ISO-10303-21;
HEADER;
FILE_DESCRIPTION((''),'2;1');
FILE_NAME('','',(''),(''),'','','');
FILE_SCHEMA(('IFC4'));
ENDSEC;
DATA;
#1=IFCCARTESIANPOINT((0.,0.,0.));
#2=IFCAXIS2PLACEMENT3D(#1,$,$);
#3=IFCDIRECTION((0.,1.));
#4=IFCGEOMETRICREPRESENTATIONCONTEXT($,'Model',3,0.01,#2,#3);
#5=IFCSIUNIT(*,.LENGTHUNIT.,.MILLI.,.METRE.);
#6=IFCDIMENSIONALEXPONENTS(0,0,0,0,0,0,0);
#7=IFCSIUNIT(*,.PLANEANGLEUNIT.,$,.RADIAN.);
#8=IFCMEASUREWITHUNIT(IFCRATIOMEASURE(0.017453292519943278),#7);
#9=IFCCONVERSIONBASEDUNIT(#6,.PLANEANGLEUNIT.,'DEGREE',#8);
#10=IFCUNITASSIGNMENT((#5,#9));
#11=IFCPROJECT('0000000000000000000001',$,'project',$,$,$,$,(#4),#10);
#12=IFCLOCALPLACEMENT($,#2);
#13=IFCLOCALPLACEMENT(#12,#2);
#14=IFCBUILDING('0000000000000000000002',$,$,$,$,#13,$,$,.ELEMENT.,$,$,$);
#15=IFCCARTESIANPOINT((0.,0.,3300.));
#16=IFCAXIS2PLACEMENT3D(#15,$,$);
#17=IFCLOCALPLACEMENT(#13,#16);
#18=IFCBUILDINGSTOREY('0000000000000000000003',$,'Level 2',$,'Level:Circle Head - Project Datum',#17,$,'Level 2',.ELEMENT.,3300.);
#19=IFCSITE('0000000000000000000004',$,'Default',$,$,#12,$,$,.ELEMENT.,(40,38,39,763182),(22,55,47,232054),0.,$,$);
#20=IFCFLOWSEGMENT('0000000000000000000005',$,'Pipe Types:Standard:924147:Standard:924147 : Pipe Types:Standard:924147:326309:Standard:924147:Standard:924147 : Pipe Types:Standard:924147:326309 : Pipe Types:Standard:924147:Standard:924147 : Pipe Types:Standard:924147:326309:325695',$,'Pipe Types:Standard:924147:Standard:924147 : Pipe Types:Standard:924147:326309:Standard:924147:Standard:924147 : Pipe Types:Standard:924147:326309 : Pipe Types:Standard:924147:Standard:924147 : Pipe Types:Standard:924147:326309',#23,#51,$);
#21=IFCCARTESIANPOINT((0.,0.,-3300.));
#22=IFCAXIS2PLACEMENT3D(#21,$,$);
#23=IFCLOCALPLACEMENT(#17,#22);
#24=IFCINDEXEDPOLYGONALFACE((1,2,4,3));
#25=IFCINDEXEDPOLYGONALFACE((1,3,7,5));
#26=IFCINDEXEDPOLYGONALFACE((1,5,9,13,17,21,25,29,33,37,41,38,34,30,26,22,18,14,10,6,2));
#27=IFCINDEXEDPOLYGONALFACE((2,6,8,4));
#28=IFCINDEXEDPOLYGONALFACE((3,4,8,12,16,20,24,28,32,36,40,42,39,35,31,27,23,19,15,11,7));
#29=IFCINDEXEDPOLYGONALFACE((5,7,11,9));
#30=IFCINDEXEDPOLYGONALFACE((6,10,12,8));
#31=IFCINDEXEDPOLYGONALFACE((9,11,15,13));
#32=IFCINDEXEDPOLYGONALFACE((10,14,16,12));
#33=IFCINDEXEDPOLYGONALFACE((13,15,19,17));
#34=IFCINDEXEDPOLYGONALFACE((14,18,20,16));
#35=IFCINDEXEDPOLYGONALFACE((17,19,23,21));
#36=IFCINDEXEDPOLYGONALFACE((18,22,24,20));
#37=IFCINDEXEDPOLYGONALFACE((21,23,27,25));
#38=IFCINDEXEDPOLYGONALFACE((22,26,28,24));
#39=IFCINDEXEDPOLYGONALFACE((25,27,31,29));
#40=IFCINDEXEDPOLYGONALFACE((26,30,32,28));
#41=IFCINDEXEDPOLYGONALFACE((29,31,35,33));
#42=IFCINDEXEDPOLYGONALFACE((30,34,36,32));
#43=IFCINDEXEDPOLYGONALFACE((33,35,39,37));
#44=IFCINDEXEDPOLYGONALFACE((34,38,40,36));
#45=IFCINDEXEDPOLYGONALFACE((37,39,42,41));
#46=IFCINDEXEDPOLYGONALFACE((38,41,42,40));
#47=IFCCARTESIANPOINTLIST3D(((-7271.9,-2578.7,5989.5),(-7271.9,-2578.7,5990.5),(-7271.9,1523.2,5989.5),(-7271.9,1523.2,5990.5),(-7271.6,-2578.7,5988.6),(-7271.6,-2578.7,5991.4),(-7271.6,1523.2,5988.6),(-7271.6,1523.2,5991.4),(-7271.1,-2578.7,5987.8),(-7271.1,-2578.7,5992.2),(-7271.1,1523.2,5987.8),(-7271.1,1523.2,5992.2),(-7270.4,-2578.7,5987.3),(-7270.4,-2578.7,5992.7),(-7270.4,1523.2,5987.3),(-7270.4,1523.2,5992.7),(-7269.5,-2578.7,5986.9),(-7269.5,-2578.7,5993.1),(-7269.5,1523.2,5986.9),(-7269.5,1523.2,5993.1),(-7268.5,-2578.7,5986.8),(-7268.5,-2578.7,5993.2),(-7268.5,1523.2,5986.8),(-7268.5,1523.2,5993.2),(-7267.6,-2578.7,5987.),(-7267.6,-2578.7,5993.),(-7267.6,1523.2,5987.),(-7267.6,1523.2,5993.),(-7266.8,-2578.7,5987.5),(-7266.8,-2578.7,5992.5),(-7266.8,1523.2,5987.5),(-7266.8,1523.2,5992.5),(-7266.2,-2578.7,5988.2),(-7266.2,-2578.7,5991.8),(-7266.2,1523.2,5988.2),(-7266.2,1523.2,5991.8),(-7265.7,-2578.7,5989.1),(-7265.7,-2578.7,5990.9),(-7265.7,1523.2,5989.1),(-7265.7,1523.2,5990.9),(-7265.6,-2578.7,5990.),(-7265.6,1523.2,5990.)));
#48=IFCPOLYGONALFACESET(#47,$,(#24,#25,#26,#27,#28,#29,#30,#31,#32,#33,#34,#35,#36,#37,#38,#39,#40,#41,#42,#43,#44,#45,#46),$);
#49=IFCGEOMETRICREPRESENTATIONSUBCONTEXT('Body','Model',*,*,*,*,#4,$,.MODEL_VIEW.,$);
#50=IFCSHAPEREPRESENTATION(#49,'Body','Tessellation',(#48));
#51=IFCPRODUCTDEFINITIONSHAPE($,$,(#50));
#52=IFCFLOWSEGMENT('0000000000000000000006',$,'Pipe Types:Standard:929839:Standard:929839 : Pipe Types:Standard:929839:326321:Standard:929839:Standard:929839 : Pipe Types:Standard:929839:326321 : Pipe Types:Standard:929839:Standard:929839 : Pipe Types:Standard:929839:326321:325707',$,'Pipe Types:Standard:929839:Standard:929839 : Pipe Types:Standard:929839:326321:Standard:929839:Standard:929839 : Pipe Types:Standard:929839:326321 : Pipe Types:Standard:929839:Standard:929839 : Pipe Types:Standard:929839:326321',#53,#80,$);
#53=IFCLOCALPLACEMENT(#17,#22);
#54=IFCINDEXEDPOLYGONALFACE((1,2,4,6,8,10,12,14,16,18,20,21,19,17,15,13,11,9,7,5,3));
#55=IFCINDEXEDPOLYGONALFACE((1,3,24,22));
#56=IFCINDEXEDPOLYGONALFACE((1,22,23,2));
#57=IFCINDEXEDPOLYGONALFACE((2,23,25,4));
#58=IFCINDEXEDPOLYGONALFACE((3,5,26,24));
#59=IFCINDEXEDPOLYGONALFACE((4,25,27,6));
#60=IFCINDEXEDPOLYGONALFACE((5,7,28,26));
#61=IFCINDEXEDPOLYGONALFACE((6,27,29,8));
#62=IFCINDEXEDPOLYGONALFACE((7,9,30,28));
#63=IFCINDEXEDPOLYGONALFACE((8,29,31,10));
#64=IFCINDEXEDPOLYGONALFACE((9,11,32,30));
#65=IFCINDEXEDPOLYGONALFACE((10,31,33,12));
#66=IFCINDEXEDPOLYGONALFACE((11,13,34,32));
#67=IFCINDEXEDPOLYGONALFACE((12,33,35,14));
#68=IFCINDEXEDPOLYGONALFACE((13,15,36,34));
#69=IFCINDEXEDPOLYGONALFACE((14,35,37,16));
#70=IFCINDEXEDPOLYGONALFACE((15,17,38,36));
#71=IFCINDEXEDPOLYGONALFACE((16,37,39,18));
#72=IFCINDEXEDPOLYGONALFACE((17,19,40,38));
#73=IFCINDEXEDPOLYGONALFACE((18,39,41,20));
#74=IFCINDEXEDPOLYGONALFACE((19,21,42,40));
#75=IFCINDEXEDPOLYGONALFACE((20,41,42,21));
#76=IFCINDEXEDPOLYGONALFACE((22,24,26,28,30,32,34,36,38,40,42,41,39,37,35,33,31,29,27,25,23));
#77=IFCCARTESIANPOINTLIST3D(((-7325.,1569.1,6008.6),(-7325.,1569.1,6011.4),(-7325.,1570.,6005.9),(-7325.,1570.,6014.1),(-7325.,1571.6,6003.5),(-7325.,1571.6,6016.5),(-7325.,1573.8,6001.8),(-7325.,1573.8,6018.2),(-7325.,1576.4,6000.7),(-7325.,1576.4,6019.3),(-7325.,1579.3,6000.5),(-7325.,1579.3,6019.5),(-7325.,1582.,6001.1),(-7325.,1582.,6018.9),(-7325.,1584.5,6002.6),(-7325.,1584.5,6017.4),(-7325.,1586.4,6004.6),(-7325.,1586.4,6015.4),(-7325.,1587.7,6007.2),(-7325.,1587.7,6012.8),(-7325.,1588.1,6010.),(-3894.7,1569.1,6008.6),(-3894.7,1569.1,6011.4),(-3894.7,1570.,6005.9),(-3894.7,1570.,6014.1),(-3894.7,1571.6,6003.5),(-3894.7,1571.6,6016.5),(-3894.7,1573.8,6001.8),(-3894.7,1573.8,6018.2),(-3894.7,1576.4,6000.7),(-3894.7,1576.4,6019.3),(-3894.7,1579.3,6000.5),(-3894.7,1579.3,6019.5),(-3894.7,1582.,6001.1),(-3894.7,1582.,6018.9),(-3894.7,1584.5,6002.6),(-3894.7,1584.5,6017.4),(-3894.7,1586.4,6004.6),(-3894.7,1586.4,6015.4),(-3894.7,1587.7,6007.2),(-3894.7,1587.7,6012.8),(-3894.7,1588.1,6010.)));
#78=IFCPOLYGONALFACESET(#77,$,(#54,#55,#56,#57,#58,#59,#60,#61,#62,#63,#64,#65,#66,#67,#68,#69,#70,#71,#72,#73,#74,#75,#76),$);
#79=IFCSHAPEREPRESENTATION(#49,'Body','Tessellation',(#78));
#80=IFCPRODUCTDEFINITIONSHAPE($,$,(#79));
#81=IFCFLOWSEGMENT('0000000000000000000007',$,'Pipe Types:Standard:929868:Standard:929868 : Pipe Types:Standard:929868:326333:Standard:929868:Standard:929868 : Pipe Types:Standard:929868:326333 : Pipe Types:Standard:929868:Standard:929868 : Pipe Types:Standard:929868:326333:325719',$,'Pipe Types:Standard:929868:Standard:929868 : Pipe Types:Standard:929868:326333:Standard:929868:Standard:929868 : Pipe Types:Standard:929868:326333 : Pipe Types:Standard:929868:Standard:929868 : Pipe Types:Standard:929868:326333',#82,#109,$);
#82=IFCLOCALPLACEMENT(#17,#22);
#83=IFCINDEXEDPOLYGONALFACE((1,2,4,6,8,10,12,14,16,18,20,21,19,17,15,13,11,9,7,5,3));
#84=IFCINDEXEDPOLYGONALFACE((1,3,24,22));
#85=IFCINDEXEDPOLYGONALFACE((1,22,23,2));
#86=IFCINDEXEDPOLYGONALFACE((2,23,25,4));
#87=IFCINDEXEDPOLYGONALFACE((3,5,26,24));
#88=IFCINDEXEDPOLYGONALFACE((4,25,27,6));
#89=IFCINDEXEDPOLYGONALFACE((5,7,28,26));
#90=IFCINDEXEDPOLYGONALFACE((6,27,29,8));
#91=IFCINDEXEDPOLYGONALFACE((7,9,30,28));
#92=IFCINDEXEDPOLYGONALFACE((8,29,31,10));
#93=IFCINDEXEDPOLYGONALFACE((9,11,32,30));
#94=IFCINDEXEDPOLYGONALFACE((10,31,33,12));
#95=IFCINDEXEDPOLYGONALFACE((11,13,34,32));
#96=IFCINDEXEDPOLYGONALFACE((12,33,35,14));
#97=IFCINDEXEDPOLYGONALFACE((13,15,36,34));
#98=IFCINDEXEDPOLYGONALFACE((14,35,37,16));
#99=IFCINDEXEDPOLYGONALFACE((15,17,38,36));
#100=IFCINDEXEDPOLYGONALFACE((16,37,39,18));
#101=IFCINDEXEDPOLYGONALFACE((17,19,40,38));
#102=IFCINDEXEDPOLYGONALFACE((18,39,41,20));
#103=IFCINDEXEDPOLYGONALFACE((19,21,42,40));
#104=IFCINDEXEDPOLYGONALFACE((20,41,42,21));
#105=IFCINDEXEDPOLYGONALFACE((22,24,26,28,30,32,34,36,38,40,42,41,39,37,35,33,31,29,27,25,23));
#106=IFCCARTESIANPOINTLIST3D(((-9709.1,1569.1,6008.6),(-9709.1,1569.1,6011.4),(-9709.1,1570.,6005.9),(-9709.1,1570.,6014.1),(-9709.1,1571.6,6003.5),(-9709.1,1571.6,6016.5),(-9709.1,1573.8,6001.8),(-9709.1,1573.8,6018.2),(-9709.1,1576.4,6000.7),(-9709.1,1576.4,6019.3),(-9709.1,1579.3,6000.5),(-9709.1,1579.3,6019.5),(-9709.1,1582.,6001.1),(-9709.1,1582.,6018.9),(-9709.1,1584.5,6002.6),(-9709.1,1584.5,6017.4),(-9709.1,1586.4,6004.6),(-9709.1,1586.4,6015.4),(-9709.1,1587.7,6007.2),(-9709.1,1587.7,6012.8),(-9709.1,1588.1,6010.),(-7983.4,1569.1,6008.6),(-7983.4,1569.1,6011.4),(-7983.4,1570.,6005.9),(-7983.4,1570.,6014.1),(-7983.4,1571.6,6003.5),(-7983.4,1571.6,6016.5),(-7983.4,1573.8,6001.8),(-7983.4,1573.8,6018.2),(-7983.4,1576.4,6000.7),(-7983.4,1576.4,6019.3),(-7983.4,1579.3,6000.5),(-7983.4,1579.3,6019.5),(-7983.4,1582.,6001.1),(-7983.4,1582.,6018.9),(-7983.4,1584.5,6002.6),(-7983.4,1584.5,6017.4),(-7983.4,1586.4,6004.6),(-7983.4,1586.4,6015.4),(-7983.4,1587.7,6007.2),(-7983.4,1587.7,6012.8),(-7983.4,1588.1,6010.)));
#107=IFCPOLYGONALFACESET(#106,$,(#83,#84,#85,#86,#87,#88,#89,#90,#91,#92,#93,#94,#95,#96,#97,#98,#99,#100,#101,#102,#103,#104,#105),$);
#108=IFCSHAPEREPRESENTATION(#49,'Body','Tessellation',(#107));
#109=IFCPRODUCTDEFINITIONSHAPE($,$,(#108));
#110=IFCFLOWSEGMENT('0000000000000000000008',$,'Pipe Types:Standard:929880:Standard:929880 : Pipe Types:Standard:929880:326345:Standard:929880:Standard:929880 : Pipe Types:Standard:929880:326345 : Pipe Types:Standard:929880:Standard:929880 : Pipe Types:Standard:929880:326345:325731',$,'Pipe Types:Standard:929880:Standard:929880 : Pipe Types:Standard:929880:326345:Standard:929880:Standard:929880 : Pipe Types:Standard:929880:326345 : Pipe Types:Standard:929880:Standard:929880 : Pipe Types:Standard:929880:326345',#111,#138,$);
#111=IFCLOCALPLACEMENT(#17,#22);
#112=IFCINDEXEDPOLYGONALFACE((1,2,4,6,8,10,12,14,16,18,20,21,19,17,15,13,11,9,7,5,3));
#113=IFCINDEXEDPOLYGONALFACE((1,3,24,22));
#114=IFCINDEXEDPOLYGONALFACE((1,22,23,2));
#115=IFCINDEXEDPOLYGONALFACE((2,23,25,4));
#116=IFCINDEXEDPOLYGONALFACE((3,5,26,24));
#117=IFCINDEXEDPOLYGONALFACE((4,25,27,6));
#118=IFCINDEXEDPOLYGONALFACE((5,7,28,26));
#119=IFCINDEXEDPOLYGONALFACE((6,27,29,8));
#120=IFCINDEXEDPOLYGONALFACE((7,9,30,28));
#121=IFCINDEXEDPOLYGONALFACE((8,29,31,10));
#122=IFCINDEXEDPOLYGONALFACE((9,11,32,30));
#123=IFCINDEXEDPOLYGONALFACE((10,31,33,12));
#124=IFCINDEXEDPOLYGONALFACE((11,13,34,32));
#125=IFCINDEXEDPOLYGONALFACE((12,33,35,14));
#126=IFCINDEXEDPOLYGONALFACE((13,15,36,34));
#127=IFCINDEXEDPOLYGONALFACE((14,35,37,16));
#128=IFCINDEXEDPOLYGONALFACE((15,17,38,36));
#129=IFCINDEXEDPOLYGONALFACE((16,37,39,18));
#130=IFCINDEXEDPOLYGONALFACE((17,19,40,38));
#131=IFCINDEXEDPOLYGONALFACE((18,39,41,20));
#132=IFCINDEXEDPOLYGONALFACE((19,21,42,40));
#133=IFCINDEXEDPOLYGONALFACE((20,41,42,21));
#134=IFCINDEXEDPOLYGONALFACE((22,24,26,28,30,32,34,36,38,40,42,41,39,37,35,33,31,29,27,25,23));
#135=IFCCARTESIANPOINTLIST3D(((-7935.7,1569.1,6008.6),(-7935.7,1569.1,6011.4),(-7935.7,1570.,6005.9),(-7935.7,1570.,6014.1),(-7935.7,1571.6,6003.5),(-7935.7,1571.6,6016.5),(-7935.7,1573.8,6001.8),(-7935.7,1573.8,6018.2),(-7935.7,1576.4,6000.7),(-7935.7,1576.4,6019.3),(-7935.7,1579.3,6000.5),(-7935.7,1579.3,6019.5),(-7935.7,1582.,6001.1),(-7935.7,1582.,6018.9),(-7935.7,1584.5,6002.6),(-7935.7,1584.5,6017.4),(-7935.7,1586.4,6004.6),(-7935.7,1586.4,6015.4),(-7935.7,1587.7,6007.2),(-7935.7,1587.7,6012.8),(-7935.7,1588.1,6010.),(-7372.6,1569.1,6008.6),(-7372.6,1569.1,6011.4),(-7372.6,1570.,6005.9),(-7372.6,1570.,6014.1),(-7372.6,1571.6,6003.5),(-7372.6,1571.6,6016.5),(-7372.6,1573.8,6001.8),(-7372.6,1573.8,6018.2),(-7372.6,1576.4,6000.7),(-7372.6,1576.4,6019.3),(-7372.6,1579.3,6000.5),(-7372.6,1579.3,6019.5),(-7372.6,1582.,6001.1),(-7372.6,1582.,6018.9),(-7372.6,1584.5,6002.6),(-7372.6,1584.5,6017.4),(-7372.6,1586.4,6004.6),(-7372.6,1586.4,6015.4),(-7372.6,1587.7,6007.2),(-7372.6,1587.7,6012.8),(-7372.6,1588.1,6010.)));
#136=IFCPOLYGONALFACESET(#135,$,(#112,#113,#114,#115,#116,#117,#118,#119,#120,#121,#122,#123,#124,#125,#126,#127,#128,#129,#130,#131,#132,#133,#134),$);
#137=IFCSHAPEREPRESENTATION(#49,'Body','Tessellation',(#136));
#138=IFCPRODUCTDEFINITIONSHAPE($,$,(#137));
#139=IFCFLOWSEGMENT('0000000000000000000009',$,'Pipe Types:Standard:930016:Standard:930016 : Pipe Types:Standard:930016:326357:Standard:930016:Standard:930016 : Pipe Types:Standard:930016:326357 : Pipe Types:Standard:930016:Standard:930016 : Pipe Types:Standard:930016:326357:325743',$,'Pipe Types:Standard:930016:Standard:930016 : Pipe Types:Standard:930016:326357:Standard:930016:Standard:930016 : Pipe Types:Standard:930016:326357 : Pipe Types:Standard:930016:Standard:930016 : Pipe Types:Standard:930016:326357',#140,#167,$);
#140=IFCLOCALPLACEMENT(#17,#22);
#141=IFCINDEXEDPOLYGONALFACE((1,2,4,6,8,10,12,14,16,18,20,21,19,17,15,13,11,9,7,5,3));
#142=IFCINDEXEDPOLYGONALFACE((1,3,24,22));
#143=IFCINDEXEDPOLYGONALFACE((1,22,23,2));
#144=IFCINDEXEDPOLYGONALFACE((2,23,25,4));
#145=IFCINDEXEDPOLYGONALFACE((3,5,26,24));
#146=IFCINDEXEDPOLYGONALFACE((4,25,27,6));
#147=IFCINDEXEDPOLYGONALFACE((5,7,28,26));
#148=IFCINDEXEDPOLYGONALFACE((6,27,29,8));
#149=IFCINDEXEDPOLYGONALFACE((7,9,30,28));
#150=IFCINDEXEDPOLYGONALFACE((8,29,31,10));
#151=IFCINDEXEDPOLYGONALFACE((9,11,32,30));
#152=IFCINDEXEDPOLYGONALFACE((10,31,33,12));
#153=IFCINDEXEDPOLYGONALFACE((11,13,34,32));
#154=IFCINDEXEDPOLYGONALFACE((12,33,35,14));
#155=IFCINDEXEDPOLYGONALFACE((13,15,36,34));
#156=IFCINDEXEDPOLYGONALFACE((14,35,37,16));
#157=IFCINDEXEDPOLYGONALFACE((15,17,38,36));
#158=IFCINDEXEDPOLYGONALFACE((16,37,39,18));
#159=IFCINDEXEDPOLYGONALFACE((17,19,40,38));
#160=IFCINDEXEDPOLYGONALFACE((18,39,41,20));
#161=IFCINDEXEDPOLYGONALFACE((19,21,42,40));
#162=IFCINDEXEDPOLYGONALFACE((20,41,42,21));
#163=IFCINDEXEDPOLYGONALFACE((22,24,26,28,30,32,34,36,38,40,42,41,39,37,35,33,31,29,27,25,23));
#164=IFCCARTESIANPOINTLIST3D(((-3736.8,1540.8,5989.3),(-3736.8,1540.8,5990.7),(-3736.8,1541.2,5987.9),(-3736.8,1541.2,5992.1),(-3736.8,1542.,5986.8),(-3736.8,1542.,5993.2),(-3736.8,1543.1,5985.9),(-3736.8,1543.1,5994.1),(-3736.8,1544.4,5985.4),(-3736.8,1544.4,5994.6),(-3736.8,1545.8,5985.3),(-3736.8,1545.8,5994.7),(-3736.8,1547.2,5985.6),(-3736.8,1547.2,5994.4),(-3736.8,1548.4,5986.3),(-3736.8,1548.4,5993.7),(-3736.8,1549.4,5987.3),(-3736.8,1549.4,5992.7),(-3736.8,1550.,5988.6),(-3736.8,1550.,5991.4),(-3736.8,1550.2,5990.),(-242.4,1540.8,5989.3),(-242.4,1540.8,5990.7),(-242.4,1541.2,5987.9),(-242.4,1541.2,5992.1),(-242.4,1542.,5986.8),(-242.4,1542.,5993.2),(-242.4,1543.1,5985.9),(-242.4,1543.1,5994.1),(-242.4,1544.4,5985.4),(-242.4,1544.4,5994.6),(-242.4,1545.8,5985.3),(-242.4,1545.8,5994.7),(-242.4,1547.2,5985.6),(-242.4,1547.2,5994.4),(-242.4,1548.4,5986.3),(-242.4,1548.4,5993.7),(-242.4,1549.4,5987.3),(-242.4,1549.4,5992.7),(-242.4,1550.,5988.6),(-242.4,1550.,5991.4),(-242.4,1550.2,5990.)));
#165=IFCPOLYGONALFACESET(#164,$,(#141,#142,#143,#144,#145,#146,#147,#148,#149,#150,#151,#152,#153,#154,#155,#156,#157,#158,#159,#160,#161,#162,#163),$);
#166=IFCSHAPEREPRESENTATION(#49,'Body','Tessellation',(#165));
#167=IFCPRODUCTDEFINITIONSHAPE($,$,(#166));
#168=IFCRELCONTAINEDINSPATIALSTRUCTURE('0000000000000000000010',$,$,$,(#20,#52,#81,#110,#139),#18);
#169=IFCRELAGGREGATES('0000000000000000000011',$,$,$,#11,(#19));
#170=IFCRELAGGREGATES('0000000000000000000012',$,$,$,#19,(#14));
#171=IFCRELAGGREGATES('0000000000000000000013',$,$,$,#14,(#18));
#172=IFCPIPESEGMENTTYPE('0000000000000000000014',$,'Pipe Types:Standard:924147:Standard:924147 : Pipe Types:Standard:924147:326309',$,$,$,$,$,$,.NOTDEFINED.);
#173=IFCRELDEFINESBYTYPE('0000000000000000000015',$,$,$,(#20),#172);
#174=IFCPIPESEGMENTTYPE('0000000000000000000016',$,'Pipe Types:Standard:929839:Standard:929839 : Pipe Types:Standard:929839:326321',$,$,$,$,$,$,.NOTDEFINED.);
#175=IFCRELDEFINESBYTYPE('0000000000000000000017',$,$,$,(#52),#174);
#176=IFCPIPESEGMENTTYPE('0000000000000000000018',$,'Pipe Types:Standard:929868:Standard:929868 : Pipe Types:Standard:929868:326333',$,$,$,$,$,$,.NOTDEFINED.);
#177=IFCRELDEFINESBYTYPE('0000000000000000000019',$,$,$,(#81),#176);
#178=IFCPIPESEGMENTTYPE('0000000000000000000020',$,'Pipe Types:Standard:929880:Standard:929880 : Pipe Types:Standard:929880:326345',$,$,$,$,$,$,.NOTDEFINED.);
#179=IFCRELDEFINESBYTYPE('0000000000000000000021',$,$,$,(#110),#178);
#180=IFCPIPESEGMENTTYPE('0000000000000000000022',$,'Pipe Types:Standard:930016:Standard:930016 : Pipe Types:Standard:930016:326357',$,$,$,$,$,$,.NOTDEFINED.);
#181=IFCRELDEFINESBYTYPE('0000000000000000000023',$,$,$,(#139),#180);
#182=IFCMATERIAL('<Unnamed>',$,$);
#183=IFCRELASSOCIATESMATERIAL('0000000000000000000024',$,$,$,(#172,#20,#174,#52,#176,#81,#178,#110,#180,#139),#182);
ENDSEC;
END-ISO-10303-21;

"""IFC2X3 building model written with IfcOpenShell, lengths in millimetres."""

from ifc_helpers import new_model, entity, si_unit, converted_unit, direction, frame, origin, origin_2d_with_axis, place, context, subcontext, project, spatial, circle, extrude, source, transform, mapped, material, type_object, type_shapes, element, save


model = new_model("IFC2X3")

# Units and contexts
model_context = context("Model", 3, precision=0.01, world=origin(), true_north=direction((0.0, 1.0)))
body_context = subcontext(model_context, "Body", "Model", "MODEL_VIEW")
ifc_project = project(units=[si_unit("LENGTHUNIT", "METRE", prefix="MILLI"), converted_unit("PLANEANGLEUNIT", "DEGREE", entity("IfcRatioMeasure", 0.017453292519943278), si_unit("PLANEANGLEUNIT", "RADIAN"), dimensions=[0, 0, 0, 0, 0, 0, 0])], contexts=[model_context])

# Site, building, storey
site_placement = place(None, origin())
site = spatial("IfcSite", under=ifc_project, at=site_placement, Name="Default", CompositionType="ELEMENT", RefLatitude=(40, 38, 39, 763182), RefLongitude=(22, 55, 47, 232054), RefElevation=0.0)
building_placement = place(site_placement, origin())
building = spatial("IfcBuilding", under=site, at=building_placement, CompositionType="ELEMENT")
storey_placement = place(building_placement, frame((0.0, 0.0, 3300.0)))
storey = spatial("IfcBuildingStorey", under=building, at=storey_placement, Name="Level 2", ObjectType="Level:Circle Head - Project Datum", LongName="Level 2", CompositionType="ELEMENT", Elevation=3300.0)

# Flow segments
ifc_material_1 = material(Name="<Unnamed>")
pipe_segment_type_1 = type_object("IfcPipeSegmentType", Name="Pipe Types:Standard:924147:Standard:924147 : Pipe Types:Standard:924147:326309", PredefinedType="NOTDEFINED", material=ifc_material_1)
shared_shape_1 = source(origin(), body_context, "Body", "SweptSolid", [
    extrude(circle(Radius=3.2, at=origin_2d_with_axis()), frame((-7268.8, -2578.7, 5990.0), z_axis=(0.0, 1.0, 0.0), x_axis=(1.0, 0.0, 0.0)), (0.0, 0.0, 1.0), 4102.0),
])
type_shapes(pipe_segment_type_1, [shared_shape_1])
flow_segment_1_placement = place(storey_placement, frame((0.0, 0.0, -3300.0)))
element("IfcFlowSegment", 1, at=flow_segment_1_placement, inside=storey, type_object=pipe_segment_type_1, material=ifc_material_1, Name="Pipe Types:Standard:924147:Standard:924147 : Pipe Types:Standard:924147:326309:Standard:924147:Standard:924147 : Pipe Types:Standard:924147:326309 : Pipe Types:Standard:924147:Standard:924147 : Pipe Types:Standard:924147:326309:325695", ObjectType="Pipe Types:Standard:924147:Standard:924147 : Pipe Types:Standard:924147:326309:Standard:924147:Standard:924147 : Pipe Types:Standard:924147:326309 : Pipe Types:Standard:924147:Standard:924147 : Pipe Types:Standard:924147:326309", context=body_context, shape_type="MappedRepresentation", body=[
    mapped(shared_shape_1, transform((0.0, 0.0, 0.0), scale=1.0)),
])
pipe_segment_type_2 = type_object("IfcPipeSegmentType", Name="Pipe Types:Standard:929839:Standard:929839 : Pipe Types:Standard:929839:326321", PredefinedType="NOTDEFINED", material=ifc_material_1)
shared_shape_2 = source(origin(), body_context, "Body", "SweptSolid", [
    extrude(circle(Radius=9.5, at=origin_2d_with_axis()), frame((-7325.0, 1578.6, 6010.0), z_axis=(1.0, 0.0, 0.0), x_axis=(0.0, 1.0, 0.0)), (0.0, 0.0, 1.0), 3430.2),
])
type_shapes(pipe_segment_type_2, [shared_shape_2])
flow_segment_2_placement = place(storey_placement, frame((0.0, 0.0, -3300.0)))
element("IfcFlowSegment", 2, at=flow_segment_2_placement, inside=storey, type_object=pipe_segment_type_2, material=ifc_material_1, Name="Pipe Types:Standard:929839:Standard:929839 : Pipe Types:Standard:929839:326321:Standard:929839:Standard:929839 : Pipe Types:Standard:929839:326321 : Pipe Types:Standard:929839:Standard:929839 : Pipe Types:Standard:929839:326321:325707", ObjectType="Pipe Types:Standard:929839:Standard:929839 : Pipe Types:Standard:929839:326321:Standard:929839:Standard:929839 : Pipe Types:Standard:929839:326321 : Pipe Types:Standard:929839:Standard:929839 : Pipe Types:Standard:929839:326321", context=body_context, shape_type="MappedRepresentation", body=[
    mapped(shared_shape_2, transform((0.0, 0.0, 0.0), scale=1.0)),
])
pipe_segment_type_3 = type_object("IfcPipeSegmentType", Name="Pipe Types:Standard:929868:Standard:929868 : Pipe Types:Standard:929868:326333", PredefinedType="NOTDEFINED", material=ifc_material_1)
shared_shape_3 = source(origin(), body_context, "Body", "SweptSolid", [
    extrude(circle(Radius=9.5, at=origin_2d_with_axis()), frame((-9709.1, 1578.6, 6010.0), z_axis=(1.0, 0.0, 0.0), x_axis=(0.0, 1.0, 0.0)), (0.0, 0.0, 1.0), 1725.8),
])
type_shapes(pipe_segment_type_3, [shared_shape_3])
flow_segment_3_placement = place(storey_placement, frame((0.0, 0.0, -3300.0)))
element("IfcFlowSegment", 3, at=flow_segment_3_placement, inside=storey, type_object=pipe_segment_type_3, material=ifc_material_1, Name="Pipe Types:Standard:929868:Standard:929868 : Pipe Types:Standard:929868:326333:Standard:929868:Standard:929868 : Pipe Types:Standard:929868:326333 : Pipe Types:Standard:929868:Standard:929868 : Pipe Types:Standard:929868:326333:325719", ObjectType="Pipe Types:Standard:929868:Standard:929868 : Pipe Types:Standard:929868:326333:Standard:929868:Standard:929868 : Pipe Types:Standard:929868:326333 : Pipe Types:Standard:929868:Standard:929868 : Pipe Types:Standard:929868:326333", context=body_context, shape_type="MappedRepresentation", body=[
    mapped(shared_shape_3, transform((0.0, 0.0, 0.0), scale=1.0)),
])
pipe_segment_type_4 = type_object("IfcPipeSegmentType", Name="Pipe Types:Standard:929880:Standard:929880 : Pipe Types:Standard:929880:326345", PredefinedType="NOTDEFINED", material=ifc_material_1)
shared_shape_4 = source(origin(), body_context, "Body", "SweptSolid", [
    extrude(circle(Radius=9.5, at=origin_2d_with_axis()), frame((-7935.7, 1578.6, 6010.0), z_axis=(1.0, 0.0, 0.0), x_axis=(0.0, 1.0, 0.0)), (0.0, 0.0, 1.0), 563.1),
])
type_shapes(pipe_segment_type_4, [shared_shape_4])
flow_segment_4_placement = place(storey_placement, frame((0.0, 0.0, -3300.0)))
element("IfcFlowSegment", 4, at=flow_segment_4_placement, inside=storey, type_object=pipe_segment_type_4, material=ifc_material_1, Name="Pipe Types:Standard:929880:Standard:929880 : Pipe Types:Standard:929880:326345:Standard:929880:Standard:929880 : Pipe Types:Standard:929880:326345 : Pipe Types:Standard:929880:Standard:929880 : Pipe Types:Standard:929880:326345:325731", ObjectType="Pipe Types:Standard:929880:Standard:929880 : Pipe Types:Standard:929880:326345:Standard:929880:Standard:929880 : Pipe Types:Standard:929880:326345 : Pipe Types:Standard:929880:Standard:929880 : Pipe Types:Standard:929880:326345", context=body_context, shape_type="MappedRepresentation", body=[
    mapped(shared_shape_4, transform((0.0, 0.0, 0.0), scale=1.0)),
])
pipe_segment_type_5 = type_object("IfcPipeSegmentType", Name="Pipe Types:Standard:930016:Standard:930016 : Pipe Types:Standard:930016:326357", PredefinedType="NOTDEFINED", material=ifc_material_1)
shared_shape_5 = source(origin(), body_context, "Body", "SweptSolid", [
    extrude(circle(Radius=4.8, at=origin_2d_with_axis()), frame((-3736.8, 1545.5, 5990.0), z_axis=(1.0, 0.0, 0.0), x_axis=(0.0, 1.0, 0.0)), (0.0, 0.0, 1.0), 3494.4),
])
type_shapes(pipe_segment_type_5, [shared_shape_5])
flow_segment_5_placement = place(storey_placement, frame((0.0, 0.0, -3300.0)))
element("IfcFlowSegment", 5, at=flow_segment_5_placement, inside=storey, type_object=pipe_segment_type_5, material=ifc_material_1, Name="Pipe Types:Standard:930016:Standard:930016 : Pipe Types:Standard:930016:326357:Standard:930016:Standard:930016 : Pipe Types:Standard:930016:326357 : Pipe Types:Standard:930016:Standard:930016 : Pipe Types:Standard:930016:326357:325743", ObjectType="Pipe Types:Standard:930016:Standard:930016 : Pipe Types:Standard:930016:326357:Standard:930016:Standard:930016 : Pipe Types:Standard:930016:326357 : Pipe Types:Standard:930016:Standard:930016 : Pipe Types:Standard:930016:326357", context=body_context, shape_type="MappedRepresentation", body=[
    mapped(shared_shape_5, transform((0.0, 0.0, 0.0), scale=1.0)),
])

save(model, "model.ifc")
